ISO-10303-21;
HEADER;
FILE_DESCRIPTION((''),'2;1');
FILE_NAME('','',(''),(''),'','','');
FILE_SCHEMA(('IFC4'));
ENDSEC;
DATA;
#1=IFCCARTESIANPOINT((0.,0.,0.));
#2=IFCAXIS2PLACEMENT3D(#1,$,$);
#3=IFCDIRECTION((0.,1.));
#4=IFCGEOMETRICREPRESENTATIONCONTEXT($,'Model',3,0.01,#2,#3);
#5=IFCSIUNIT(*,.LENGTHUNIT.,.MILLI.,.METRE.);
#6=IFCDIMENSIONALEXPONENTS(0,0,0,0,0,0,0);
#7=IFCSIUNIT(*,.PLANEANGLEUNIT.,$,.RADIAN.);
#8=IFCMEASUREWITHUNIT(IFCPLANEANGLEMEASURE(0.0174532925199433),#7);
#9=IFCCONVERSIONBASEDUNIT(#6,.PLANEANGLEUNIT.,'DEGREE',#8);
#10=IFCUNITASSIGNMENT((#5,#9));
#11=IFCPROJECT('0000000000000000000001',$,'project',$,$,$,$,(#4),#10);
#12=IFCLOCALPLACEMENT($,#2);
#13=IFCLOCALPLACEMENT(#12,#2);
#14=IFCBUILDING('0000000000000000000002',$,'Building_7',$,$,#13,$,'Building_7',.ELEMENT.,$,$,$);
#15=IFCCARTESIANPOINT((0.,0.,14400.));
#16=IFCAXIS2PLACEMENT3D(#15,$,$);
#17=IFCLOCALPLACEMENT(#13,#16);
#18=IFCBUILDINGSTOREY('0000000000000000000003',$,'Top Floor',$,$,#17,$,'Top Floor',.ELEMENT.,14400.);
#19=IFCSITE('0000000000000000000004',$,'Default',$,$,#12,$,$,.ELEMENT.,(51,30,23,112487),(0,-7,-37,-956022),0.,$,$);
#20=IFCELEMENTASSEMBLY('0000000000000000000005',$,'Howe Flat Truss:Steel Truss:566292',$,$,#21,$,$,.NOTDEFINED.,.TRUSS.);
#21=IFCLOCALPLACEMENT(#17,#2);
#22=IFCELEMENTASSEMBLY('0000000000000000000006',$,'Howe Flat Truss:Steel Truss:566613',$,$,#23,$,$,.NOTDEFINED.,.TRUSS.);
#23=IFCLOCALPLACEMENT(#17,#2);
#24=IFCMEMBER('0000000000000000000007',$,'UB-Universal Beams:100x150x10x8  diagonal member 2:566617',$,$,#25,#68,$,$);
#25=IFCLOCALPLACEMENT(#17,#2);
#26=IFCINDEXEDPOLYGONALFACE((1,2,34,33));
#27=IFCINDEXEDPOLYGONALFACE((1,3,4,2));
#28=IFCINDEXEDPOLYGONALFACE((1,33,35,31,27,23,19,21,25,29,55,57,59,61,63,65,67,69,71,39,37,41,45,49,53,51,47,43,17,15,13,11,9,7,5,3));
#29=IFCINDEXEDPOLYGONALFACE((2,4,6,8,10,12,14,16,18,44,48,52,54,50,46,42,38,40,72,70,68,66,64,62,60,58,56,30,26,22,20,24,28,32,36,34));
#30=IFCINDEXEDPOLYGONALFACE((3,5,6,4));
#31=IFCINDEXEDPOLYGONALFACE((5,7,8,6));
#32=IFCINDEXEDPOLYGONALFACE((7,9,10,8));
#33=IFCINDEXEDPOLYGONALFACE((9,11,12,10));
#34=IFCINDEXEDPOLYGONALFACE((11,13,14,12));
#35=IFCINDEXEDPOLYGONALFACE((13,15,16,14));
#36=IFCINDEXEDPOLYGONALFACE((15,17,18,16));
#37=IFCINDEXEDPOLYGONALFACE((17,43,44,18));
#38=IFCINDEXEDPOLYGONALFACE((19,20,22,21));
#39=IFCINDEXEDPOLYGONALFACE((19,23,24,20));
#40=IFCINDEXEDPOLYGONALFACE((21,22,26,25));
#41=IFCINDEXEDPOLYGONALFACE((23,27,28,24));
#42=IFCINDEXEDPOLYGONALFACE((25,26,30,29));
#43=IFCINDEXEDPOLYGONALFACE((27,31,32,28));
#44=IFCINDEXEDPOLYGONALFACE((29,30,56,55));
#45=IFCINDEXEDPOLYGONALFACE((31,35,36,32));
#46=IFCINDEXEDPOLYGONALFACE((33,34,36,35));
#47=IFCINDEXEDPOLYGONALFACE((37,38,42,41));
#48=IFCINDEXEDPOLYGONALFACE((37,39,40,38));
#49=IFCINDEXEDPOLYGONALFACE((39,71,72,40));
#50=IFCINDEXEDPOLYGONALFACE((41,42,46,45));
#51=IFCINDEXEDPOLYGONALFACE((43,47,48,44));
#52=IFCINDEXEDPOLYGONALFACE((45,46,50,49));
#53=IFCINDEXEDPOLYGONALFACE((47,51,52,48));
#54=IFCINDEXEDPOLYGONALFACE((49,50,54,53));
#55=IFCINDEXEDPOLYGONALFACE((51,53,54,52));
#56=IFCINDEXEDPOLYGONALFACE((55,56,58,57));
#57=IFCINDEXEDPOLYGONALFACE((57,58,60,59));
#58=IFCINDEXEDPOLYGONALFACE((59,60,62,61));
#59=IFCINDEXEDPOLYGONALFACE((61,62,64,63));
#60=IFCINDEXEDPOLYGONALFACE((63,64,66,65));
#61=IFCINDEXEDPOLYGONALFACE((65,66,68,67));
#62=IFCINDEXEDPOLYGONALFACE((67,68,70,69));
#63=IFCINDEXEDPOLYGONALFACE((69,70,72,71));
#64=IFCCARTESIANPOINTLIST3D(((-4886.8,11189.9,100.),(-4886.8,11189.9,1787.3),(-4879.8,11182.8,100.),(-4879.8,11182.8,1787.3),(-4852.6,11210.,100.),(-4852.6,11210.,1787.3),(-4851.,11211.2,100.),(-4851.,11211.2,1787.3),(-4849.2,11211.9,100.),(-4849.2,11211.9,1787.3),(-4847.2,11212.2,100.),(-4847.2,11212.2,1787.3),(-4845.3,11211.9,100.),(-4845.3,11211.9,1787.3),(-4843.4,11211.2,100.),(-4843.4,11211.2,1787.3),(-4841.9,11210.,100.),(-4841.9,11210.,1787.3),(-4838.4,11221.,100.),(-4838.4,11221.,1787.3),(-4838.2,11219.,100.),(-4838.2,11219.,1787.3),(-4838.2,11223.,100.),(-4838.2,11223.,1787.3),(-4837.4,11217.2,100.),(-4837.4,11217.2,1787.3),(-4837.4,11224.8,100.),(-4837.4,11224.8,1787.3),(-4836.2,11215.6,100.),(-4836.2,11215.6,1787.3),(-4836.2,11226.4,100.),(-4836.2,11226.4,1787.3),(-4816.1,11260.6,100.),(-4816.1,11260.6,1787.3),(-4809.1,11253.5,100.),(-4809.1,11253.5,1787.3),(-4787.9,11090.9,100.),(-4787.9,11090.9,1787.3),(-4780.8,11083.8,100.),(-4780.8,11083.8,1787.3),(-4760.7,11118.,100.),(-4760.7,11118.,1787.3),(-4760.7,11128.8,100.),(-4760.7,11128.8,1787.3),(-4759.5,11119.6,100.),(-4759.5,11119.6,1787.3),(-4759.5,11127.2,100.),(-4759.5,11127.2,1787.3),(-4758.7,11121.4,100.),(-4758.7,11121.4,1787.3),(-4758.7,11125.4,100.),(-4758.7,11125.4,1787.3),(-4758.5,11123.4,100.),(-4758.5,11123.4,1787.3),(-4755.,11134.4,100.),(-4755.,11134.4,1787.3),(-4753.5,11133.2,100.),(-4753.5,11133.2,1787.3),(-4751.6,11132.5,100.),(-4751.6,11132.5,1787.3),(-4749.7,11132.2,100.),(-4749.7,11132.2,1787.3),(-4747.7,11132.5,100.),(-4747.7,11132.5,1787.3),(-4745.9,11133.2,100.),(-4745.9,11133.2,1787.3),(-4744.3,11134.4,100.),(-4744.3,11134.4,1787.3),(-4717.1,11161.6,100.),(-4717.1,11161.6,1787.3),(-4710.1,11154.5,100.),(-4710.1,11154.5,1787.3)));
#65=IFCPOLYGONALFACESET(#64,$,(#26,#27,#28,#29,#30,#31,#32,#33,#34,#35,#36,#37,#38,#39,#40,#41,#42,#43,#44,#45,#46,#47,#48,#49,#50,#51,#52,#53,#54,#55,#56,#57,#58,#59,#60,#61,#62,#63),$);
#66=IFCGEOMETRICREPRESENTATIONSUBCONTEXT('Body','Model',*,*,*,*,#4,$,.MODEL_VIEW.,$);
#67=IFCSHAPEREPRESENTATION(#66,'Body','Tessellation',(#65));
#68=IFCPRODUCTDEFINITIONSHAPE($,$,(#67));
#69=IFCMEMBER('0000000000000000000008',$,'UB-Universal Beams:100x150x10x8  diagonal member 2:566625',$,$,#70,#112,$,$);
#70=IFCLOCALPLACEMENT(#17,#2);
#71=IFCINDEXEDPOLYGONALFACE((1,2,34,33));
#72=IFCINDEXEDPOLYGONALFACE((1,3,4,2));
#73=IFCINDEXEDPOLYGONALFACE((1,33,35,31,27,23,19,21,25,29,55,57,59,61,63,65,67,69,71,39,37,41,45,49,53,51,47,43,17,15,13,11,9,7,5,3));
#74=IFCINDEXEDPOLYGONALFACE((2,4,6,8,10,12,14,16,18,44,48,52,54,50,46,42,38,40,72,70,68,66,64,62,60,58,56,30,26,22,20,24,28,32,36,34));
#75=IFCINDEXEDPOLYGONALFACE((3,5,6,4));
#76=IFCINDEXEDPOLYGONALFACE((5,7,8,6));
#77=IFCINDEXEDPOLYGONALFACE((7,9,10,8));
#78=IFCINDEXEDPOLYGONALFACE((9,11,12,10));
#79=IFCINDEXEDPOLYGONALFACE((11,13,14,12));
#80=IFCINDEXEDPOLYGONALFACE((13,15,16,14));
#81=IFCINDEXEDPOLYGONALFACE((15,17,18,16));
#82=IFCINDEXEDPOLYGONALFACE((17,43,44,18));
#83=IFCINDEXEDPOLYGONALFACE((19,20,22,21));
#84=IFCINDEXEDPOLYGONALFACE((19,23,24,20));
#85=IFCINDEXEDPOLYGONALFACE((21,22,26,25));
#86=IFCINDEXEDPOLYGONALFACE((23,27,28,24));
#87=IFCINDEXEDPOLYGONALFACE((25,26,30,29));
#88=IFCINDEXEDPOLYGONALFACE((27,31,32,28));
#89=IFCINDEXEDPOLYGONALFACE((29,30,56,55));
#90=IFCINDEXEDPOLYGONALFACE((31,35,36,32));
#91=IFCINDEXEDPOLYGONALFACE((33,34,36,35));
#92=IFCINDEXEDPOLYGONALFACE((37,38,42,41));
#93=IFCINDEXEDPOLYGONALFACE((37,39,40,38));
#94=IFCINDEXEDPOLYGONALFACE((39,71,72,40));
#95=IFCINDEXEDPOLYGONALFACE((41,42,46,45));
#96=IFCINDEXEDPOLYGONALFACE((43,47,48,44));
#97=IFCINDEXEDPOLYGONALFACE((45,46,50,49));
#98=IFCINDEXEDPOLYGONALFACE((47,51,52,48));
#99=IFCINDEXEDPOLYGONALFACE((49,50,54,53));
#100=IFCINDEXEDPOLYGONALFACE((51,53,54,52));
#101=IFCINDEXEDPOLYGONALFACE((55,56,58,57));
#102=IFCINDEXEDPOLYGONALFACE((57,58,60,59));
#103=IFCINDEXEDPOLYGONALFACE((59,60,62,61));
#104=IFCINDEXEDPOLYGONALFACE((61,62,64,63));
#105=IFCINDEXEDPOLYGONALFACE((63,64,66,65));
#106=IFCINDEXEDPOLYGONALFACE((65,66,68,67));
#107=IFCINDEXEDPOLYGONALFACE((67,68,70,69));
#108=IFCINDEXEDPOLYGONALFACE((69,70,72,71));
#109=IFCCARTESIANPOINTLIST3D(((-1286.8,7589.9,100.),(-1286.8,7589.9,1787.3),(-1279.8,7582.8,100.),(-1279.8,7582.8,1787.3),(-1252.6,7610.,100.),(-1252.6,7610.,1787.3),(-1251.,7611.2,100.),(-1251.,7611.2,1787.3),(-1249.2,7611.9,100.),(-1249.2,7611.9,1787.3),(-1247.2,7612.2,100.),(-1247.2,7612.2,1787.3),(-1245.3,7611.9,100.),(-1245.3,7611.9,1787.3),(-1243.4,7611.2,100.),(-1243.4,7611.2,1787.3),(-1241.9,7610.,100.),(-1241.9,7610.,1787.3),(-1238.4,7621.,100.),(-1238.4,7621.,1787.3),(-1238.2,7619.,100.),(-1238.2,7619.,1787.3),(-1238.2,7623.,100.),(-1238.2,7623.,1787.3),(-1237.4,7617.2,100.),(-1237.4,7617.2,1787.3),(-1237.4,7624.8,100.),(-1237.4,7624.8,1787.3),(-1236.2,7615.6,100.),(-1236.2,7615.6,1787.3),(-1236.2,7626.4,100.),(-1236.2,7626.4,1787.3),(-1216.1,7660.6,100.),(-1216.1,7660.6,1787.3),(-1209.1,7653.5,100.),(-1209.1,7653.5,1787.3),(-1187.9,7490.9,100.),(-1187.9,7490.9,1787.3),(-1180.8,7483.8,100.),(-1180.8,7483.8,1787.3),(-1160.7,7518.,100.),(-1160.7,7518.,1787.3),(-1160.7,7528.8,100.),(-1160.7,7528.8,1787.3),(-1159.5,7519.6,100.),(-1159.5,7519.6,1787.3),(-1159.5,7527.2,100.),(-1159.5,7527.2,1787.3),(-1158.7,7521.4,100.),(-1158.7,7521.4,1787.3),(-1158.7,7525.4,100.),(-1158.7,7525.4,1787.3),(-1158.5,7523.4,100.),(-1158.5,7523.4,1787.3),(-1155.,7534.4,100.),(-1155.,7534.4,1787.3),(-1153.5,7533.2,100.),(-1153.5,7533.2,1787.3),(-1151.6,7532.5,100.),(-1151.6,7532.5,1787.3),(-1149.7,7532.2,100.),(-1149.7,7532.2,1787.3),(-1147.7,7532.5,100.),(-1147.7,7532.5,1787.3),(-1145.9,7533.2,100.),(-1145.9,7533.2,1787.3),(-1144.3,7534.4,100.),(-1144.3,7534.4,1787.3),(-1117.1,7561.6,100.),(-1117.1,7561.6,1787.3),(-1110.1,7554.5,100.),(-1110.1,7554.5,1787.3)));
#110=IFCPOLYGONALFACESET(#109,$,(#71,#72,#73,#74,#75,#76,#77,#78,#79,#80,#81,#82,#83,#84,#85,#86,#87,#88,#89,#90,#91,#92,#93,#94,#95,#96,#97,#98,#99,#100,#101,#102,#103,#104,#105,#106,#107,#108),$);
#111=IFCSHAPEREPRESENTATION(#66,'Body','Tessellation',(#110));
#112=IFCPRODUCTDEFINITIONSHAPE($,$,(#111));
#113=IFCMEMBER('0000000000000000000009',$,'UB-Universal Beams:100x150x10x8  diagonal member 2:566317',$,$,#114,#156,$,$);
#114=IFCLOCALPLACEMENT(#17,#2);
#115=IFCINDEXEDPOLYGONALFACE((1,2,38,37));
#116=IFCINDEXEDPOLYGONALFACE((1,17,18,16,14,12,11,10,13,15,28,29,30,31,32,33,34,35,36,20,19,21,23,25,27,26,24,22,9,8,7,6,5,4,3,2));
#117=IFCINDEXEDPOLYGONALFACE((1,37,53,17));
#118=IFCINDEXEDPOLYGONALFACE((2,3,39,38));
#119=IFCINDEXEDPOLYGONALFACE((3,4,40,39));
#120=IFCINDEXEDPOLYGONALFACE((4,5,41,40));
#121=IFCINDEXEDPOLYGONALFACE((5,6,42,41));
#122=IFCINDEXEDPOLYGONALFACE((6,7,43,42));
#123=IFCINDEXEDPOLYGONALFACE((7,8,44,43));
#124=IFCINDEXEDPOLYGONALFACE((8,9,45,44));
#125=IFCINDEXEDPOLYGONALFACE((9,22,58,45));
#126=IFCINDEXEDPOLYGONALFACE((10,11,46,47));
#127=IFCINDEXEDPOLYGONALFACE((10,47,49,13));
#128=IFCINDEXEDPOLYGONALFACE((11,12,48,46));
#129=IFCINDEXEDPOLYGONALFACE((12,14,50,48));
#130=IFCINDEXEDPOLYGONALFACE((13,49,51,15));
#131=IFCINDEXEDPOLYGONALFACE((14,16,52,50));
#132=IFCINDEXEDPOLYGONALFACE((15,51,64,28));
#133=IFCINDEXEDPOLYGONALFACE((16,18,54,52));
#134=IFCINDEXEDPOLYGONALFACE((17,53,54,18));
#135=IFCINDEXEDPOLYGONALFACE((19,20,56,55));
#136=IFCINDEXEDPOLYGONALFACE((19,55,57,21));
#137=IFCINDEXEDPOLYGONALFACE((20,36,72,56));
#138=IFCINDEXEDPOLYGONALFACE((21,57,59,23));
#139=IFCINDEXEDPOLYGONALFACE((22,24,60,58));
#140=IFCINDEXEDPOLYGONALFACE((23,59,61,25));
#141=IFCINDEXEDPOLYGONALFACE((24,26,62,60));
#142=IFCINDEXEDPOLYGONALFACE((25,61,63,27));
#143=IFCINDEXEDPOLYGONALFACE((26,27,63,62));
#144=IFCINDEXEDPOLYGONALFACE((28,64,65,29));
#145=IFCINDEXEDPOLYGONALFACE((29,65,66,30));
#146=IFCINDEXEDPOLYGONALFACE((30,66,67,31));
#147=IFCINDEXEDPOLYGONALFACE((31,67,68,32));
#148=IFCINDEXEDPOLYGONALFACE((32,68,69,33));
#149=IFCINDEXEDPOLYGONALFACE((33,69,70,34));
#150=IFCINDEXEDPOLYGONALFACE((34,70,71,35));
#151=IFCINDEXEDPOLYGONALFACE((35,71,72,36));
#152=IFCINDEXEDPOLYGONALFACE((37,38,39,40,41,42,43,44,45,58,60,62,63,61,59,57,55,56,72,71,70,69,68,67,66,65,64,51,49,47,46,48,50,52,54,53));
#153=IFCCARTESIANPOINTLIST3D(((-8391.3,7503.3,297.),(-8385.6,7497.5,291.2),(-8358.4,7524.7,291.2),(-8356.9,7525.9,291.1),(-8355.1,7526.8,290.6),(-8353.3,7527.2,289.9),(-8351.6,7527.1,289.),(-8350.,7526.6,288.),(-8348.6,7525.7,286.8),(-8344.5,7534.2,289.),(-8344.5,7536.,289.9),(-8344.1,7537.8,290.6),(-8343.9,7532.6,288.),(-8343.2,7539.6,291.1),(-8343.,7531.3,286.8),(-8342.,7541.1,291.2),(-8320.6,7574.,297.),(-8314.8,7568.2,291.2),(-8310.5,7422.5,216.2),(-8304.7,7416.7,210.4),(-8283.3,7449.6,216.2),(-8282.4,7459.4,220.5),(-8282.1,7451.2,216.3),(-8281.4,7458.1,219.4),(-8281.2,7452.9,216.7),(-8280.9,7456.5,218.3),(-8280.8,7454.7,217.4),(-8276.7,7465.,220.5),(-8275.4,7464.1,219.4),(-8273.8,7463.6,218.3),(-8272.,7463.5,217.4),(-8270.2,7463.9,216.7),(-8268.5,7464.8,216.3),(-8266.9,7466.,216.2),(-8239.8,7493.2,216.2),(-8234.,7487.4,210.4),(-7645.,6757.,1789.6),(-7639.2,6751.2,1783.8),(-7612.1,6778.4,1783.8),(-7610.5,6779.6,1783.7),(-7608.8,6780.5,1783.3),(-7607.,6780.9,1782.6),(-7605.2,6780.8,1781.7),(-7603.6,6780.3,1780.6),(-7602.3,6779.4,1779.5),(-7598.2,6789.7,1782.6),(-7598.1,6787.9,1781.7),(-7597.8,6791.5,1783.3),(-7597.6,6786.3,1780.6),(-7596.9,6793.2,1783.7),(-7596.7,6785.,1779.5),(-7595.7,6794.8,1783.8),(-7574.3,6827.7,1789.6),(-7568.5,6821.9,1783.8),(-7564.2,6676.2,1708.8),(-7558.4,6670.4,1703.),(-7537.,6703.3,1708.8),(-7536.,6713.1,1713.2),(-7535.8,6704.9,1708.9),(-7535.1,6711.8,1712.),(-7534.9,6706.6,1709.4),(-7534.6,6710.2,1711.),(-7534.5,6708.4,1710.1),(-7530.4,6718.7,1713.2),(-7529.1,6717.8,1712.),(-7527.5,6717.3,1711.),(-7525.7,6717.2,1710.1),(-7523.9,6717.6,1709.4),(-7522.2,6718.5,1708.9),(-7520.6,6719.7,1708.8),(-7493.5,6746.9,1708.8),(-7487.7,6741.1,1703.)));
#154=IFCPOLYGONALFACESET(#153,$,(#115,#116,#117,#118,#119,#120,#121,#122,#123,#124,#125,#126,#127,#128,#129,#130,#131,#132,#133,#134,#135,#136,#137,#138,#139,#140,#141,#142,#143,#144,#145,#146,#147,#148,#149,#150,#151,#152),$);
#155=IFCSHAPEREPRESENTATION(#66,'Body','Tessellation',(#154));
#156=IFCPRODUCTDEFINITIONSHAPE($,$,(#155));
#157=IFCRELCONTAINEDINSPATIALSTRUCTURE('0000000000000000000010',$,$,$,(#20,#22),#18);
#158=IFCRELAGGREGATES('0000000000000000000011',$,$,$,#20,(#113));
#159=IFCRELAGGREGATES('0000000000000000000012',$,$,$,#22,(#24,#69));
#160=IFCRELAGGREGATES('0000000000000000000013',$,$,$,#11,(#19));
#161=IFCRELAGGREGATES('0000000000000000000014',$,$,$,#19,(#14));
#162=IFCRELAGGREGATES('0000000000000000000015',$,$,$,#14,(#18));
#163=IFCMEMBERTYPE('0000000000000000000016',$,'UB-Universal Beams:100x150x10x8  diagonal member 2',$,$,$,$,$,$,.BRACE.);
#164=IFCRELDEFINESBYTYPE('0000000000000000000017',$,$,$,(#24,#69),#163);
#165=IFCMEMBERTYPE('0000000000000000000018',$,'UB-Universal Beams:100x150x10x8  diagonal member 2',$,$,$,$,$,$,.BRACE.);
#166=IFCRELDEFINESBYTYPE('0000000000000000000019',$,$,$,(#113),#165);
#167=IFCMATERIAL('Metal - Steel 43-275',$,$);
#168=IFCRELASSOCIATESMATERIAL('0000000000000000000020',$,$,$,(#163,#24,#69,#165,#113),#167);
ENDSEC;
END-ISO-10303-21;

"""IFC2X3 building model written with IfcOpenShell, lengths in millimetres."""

from ifc_helpers import new_model, entity, si_unit, converted_unit, direction, frame, frame_2d, origin, place, context, subcontext, project, spatial, polyline, circle_curve, parameter, trimmed, segment, composite_curve, outline, extrude, source, transform, mapped, material, type_object, type_shapes, element, aggregate, save


model = new_model("IFC2X3")

# Units and contexts
model_context = context("Model", 3, precision=0.01, world=origin(), true_north=direction((0.0, 1.0)))
body_context = subcontext(model_context, "Body", "Model", "MODEL_VIEW")
ifc_project = project(units=[si_unit("LENGTHUNIT", "METRE", prefix="MILLI"), converted_unit("PLANEANGLEUNIT", "DEGREE", entity("IfcPlaneAngleMeasure", 0.0174532925199433), si_unit("PLANEANGLEUNIT", "RADIAN"), dimensions=[0, 0, 0, 0, 0, 0, 0])], contexts=[model_context])

# Site, building, storey
site_placement = place(None, origin())
site = spatial("IfcSite", under=ifc_project, at=site_placement, Name="Default", CompositionType="ELEMENT", RefLatitude=(51, 30, 23, 112487), RefLongitude=(0, -7, -37, -956022), RefElevation=0.0)
building_placement = place(site_placement, origin())
building = spatial("IfcBuilding", under=site, at=building_placement, Name="Building_7", LongName="Building_7", CompositionType="ELEMENT")
storey_placement = place(building_placement, frame((0.0, 0.0, 14400.0)))
storey = spatial("IfcBuildingStorey", under=building, at=storey_placement, Name="Top Floor", LongName="Top Floor", CompositionType="ELEMENT", Elevation=14400.0)

# Shared definitions
ifc_material = material(Name="Metal - Steel 43-275")

# Element assembly
assembly_1_placement = place(storey_placement, origin())
assembly_1 = element("IfcElementAssembly", 1, at=assembly_1_placement, inside=storey, Name="Howe Flat Truss:Steel Truss:566292", AssemblyPlace="NOTDEFINED", PredefinedType="TRUSS")

# Element assembly
assembly_2_placement = place(storey_placement, origin())
assembly_2 = element("IfcElementAssembly", 2, at=assembly_2_placement, inside=storey, Name="Howe Flat Truss:Steel Truss:566613", AssemblyPlace="NOTDEFINED", PredefinedType="TRUSS")

# Members
member_type_1 = type_object("IfcMemberType", Name="UB-Universal Beams:100x150x10x8  diagonal member 2", PredefinedType="BRACE", material=ifc_material)
shared_shape_1 = source(origin(), body_context, "Body", "SweptSolid", [
    extrude(outline(composite_curve([segment(polyline([(-50.0, -65.0), (-50.0, -75.0)]), True, "CONTINUOUS"), segment(polyline([(-50.0, -75.0), (50.0, -75.0)]), True, "CONTINUOUS"), segment(polyline([(50.0, -75.0), (50.0, -65.0)]), True, "CONTINUOUS"), segment(polyline([(50.0, -65.0), (11.6, -65.0)]), True, "CONTINUOUS"), segment(trimmed(circle_curve(frame_2d((11.6, -57.4), x_axis=(1.0, 0.0)), 7.6), [parameter(180.0)], [parameter(270.0)], True, "PARAMETER"), False, "CONTINUOUS"), segment(polyline([(4.0, -57.4), (4.0, 57.4)]), True, "CONTINUOUS"), segment(trimmed(circle_curve(frame_2d((11.6, 57.4), x_axis=(1.0, 0.0)), 7.6), [parameter(90.0)], [parameter(180.0)], True, "PARAMETER"), False, "CONTINUOUS"), segment(polyline([(11.6, 65.0), (50.0, 65.0)]), True, "CONTINUOUS"), segment(polyline([(50.0, 65.0), (50.0, 75.0)]), True, "CONTINUOUS"), segment(polyline([(50.0, 75.0), (-50.0, 75.0)]), True, "CONTINUOUS"), segment(polyline([(-50.0, 75.0), (-50.0, 65.0)]), True, "CONTINUOUS"), segment(polyline([(-50.0, 65.0), (-11.6, 65.0)]), True, "CONTINUOUS"), segment(trimmed(circle_curve(frame_2d((-11.6, 57.4), x_axis=(1.0, 0.0)), 7.6), [parameter(360.0)], [parameter(90.0)], True, "PARAMETER"), False, "CONTINUOUS"), segment(polyline([(-4.0, 57.4), (-4.0, -57.4)]), True, "CONTINUOUS"), segment(trimmed(circle_curve(frame_2d((-11.6, -57.4), x_axis=(1.0, 0.0)), 7.6), [parameter(270.0)], [parameter(360.0)], True, "PARAMETER"), False, "CONTINUOUS"), segment(polyline([(-11.6, -65.0), (-50.0, -65.0)]), True, "CONTINUOUS")], self_intersect=False)), frame((-900.0, 0.0, 0.0), z_axis=(-1.0, 0.0, 0.0), x_axis=(0.0, -1.0, 0.0)), (0.0, 0.0, -1.0), 1687.3),
])
type_shapes(member_type_1, [shared_shape_1])
member_1_placement = place(assembly_2_placement, frame((-4798.5, 11172.2, 1000.0), z_axis=(0.707107, -0.707107, 0.0), x_axis=(0.0, 0.0, 1.0)))
member_1 = element("IfcMember", 3, at=member_1_placement, type_object=member_type_1, material=ifc_material, Name="UB-Universal Beams:100x150x10x8  diagonal member 2:566617", context=body_context, shape_type="MappedRepresentation", body=[
    mapped(shared_shape_1, transform((0.0, 0.0, 0.0), scale=1.0)),
])
member_2_placement = place(assembly_2_placement, frame((-1198.5, 7572.2, 1000.0), z_axis=(0.707107, -0.707107, 0.0), x_axis=(0.0, 0.0, 1.0)))
member_2 = element("IfcMember", 4, at=member_2_placement, type_object=member_type_1, material=ifc_material, Name="UB-Universal Beams:100x150x10x8  diagonal member 2:566625", context=body_context, shape_type="MappedRepresentation", body=[
    mapped(shared_shape_1, transform((0.0, 0.0, 0.0), scale=1.0)),
])
member_type_2 = type_object("IfcMemberType", Name="UB-Universal Beams:100x150x10x8  diagonal member 2", PredefinedType="BRACE", material=ifc_material)
shared_shape_2 = source(origin(), body_context, "Body", "SweptSolid", [
    extrude(outline(composite_curve([segment(polyline([(-50.0, -65.0), (-50.0, -75.0)]), True, "CONTINUOUS"), segment(polyline([(-50.0, -75.0), (50.0, -75.0)]), True, "CONTINUOUS"), segment(polyline([(50.0, -75.0), (50.0, -65.0)]), True, "CONTINUOUS"), segment(polyline([(50.0, -65.0), (11.6, -65.0)]), True, "CONTINUOUS"), segment(trimmed(circle_curve(frame_2d((11.6, -57.4), x_axis=(1.0, 0.0)), 7.6), [parameter(180.0)], [parameter(270.0)], True, "PARAMETER"), False, "CONTINUOUS"), segment(polyline([(4.0, -57.4), (4.0, 57.4)]), True, "CONTINUOUS"), segment(trimmed(circle_curve(frame_2d((11.6, 57.4), x_axis=(1.0, 0.0)), 7.6), [parameter(90.0)], [parameter(180.0)], True, "PARAMETER"), False, "CONTINUOUS"), segment(polyline([(11.6, 65.0), (50.0, 65.0)]), True, "CONTINUOUS"), segment(polyline([(50.0, 65.0), (50.0, 75.0)]), True, "CONTINUOUS"), segment(polyline([(50.0, 75.0), (-50.0, 75.0)]), True, "CONTINUOUS"), segment(polyline([(-50.0, 75.0), (-50.0, 65.0)]), True, "CONTINUOUS"), segment(polyline([(-50.0, 65.0), (-11.6, 65.0)]), True, "CONTINUOUS"), segment(trimmed(circle_curve(frame_2d((-11.6, 57.4), x_axis=(1.0, 0.0)), 7.6), [parameter(360.0)], [parameter(90.0)], True, "PARAMETER"), False, "CONTINUOUS"), segment(polyline([(-4.0, 57.4), (-4.0, -57.4)]), True, "CONTINUOUS"), segment(trimmed(circle_curve(frame_2d((-11.6, -57.4), x_axis=(1.0, 0.0)), 7.6), [parameter(270.0)], [parameter(360.0)], True, "PARAMETER"), False, "CONTINUOUS"), segment(polyline([(-11.6, -65.0), (-50.0, -65.0)]), True, "CONTINUOUS")], self_intersect=False)), frame((-914.0, 0.0, 0.0), z_axis=(-1.0, 0.0, 0.0), x_axis=(0.0, -1.0, 0.0)), (0.0, 0.0, -1.0), 1828.1),
])
type_shapes(member_type_2, [shared_shape_2])
member_3_placement = place(assembly_1_placement, frame((-7939.5, 7122.2, 1000.0), z_axis=(0.57735, -0.57735, -0.57735), x_axis=(-0.408248, 0.408248, -0.816497)))
member_3 = element("IfcMember", 5, at=member_3_placement, type_object=member_type_2, material=ifc_material, Name="UB-Universal Beams:100x150x10x8  diagonal member 2:566317", context=body_context, shape_type="MappedRepresentation", body=[
    mapped(shared_shape_2, transform((0.0, 0.0, 0.0), scale=1.0)),
])
aggregate(assembly_1, [member_3])
aggregate(assembly_2, [member_1, member_2])

save(model, "model.ifc")
